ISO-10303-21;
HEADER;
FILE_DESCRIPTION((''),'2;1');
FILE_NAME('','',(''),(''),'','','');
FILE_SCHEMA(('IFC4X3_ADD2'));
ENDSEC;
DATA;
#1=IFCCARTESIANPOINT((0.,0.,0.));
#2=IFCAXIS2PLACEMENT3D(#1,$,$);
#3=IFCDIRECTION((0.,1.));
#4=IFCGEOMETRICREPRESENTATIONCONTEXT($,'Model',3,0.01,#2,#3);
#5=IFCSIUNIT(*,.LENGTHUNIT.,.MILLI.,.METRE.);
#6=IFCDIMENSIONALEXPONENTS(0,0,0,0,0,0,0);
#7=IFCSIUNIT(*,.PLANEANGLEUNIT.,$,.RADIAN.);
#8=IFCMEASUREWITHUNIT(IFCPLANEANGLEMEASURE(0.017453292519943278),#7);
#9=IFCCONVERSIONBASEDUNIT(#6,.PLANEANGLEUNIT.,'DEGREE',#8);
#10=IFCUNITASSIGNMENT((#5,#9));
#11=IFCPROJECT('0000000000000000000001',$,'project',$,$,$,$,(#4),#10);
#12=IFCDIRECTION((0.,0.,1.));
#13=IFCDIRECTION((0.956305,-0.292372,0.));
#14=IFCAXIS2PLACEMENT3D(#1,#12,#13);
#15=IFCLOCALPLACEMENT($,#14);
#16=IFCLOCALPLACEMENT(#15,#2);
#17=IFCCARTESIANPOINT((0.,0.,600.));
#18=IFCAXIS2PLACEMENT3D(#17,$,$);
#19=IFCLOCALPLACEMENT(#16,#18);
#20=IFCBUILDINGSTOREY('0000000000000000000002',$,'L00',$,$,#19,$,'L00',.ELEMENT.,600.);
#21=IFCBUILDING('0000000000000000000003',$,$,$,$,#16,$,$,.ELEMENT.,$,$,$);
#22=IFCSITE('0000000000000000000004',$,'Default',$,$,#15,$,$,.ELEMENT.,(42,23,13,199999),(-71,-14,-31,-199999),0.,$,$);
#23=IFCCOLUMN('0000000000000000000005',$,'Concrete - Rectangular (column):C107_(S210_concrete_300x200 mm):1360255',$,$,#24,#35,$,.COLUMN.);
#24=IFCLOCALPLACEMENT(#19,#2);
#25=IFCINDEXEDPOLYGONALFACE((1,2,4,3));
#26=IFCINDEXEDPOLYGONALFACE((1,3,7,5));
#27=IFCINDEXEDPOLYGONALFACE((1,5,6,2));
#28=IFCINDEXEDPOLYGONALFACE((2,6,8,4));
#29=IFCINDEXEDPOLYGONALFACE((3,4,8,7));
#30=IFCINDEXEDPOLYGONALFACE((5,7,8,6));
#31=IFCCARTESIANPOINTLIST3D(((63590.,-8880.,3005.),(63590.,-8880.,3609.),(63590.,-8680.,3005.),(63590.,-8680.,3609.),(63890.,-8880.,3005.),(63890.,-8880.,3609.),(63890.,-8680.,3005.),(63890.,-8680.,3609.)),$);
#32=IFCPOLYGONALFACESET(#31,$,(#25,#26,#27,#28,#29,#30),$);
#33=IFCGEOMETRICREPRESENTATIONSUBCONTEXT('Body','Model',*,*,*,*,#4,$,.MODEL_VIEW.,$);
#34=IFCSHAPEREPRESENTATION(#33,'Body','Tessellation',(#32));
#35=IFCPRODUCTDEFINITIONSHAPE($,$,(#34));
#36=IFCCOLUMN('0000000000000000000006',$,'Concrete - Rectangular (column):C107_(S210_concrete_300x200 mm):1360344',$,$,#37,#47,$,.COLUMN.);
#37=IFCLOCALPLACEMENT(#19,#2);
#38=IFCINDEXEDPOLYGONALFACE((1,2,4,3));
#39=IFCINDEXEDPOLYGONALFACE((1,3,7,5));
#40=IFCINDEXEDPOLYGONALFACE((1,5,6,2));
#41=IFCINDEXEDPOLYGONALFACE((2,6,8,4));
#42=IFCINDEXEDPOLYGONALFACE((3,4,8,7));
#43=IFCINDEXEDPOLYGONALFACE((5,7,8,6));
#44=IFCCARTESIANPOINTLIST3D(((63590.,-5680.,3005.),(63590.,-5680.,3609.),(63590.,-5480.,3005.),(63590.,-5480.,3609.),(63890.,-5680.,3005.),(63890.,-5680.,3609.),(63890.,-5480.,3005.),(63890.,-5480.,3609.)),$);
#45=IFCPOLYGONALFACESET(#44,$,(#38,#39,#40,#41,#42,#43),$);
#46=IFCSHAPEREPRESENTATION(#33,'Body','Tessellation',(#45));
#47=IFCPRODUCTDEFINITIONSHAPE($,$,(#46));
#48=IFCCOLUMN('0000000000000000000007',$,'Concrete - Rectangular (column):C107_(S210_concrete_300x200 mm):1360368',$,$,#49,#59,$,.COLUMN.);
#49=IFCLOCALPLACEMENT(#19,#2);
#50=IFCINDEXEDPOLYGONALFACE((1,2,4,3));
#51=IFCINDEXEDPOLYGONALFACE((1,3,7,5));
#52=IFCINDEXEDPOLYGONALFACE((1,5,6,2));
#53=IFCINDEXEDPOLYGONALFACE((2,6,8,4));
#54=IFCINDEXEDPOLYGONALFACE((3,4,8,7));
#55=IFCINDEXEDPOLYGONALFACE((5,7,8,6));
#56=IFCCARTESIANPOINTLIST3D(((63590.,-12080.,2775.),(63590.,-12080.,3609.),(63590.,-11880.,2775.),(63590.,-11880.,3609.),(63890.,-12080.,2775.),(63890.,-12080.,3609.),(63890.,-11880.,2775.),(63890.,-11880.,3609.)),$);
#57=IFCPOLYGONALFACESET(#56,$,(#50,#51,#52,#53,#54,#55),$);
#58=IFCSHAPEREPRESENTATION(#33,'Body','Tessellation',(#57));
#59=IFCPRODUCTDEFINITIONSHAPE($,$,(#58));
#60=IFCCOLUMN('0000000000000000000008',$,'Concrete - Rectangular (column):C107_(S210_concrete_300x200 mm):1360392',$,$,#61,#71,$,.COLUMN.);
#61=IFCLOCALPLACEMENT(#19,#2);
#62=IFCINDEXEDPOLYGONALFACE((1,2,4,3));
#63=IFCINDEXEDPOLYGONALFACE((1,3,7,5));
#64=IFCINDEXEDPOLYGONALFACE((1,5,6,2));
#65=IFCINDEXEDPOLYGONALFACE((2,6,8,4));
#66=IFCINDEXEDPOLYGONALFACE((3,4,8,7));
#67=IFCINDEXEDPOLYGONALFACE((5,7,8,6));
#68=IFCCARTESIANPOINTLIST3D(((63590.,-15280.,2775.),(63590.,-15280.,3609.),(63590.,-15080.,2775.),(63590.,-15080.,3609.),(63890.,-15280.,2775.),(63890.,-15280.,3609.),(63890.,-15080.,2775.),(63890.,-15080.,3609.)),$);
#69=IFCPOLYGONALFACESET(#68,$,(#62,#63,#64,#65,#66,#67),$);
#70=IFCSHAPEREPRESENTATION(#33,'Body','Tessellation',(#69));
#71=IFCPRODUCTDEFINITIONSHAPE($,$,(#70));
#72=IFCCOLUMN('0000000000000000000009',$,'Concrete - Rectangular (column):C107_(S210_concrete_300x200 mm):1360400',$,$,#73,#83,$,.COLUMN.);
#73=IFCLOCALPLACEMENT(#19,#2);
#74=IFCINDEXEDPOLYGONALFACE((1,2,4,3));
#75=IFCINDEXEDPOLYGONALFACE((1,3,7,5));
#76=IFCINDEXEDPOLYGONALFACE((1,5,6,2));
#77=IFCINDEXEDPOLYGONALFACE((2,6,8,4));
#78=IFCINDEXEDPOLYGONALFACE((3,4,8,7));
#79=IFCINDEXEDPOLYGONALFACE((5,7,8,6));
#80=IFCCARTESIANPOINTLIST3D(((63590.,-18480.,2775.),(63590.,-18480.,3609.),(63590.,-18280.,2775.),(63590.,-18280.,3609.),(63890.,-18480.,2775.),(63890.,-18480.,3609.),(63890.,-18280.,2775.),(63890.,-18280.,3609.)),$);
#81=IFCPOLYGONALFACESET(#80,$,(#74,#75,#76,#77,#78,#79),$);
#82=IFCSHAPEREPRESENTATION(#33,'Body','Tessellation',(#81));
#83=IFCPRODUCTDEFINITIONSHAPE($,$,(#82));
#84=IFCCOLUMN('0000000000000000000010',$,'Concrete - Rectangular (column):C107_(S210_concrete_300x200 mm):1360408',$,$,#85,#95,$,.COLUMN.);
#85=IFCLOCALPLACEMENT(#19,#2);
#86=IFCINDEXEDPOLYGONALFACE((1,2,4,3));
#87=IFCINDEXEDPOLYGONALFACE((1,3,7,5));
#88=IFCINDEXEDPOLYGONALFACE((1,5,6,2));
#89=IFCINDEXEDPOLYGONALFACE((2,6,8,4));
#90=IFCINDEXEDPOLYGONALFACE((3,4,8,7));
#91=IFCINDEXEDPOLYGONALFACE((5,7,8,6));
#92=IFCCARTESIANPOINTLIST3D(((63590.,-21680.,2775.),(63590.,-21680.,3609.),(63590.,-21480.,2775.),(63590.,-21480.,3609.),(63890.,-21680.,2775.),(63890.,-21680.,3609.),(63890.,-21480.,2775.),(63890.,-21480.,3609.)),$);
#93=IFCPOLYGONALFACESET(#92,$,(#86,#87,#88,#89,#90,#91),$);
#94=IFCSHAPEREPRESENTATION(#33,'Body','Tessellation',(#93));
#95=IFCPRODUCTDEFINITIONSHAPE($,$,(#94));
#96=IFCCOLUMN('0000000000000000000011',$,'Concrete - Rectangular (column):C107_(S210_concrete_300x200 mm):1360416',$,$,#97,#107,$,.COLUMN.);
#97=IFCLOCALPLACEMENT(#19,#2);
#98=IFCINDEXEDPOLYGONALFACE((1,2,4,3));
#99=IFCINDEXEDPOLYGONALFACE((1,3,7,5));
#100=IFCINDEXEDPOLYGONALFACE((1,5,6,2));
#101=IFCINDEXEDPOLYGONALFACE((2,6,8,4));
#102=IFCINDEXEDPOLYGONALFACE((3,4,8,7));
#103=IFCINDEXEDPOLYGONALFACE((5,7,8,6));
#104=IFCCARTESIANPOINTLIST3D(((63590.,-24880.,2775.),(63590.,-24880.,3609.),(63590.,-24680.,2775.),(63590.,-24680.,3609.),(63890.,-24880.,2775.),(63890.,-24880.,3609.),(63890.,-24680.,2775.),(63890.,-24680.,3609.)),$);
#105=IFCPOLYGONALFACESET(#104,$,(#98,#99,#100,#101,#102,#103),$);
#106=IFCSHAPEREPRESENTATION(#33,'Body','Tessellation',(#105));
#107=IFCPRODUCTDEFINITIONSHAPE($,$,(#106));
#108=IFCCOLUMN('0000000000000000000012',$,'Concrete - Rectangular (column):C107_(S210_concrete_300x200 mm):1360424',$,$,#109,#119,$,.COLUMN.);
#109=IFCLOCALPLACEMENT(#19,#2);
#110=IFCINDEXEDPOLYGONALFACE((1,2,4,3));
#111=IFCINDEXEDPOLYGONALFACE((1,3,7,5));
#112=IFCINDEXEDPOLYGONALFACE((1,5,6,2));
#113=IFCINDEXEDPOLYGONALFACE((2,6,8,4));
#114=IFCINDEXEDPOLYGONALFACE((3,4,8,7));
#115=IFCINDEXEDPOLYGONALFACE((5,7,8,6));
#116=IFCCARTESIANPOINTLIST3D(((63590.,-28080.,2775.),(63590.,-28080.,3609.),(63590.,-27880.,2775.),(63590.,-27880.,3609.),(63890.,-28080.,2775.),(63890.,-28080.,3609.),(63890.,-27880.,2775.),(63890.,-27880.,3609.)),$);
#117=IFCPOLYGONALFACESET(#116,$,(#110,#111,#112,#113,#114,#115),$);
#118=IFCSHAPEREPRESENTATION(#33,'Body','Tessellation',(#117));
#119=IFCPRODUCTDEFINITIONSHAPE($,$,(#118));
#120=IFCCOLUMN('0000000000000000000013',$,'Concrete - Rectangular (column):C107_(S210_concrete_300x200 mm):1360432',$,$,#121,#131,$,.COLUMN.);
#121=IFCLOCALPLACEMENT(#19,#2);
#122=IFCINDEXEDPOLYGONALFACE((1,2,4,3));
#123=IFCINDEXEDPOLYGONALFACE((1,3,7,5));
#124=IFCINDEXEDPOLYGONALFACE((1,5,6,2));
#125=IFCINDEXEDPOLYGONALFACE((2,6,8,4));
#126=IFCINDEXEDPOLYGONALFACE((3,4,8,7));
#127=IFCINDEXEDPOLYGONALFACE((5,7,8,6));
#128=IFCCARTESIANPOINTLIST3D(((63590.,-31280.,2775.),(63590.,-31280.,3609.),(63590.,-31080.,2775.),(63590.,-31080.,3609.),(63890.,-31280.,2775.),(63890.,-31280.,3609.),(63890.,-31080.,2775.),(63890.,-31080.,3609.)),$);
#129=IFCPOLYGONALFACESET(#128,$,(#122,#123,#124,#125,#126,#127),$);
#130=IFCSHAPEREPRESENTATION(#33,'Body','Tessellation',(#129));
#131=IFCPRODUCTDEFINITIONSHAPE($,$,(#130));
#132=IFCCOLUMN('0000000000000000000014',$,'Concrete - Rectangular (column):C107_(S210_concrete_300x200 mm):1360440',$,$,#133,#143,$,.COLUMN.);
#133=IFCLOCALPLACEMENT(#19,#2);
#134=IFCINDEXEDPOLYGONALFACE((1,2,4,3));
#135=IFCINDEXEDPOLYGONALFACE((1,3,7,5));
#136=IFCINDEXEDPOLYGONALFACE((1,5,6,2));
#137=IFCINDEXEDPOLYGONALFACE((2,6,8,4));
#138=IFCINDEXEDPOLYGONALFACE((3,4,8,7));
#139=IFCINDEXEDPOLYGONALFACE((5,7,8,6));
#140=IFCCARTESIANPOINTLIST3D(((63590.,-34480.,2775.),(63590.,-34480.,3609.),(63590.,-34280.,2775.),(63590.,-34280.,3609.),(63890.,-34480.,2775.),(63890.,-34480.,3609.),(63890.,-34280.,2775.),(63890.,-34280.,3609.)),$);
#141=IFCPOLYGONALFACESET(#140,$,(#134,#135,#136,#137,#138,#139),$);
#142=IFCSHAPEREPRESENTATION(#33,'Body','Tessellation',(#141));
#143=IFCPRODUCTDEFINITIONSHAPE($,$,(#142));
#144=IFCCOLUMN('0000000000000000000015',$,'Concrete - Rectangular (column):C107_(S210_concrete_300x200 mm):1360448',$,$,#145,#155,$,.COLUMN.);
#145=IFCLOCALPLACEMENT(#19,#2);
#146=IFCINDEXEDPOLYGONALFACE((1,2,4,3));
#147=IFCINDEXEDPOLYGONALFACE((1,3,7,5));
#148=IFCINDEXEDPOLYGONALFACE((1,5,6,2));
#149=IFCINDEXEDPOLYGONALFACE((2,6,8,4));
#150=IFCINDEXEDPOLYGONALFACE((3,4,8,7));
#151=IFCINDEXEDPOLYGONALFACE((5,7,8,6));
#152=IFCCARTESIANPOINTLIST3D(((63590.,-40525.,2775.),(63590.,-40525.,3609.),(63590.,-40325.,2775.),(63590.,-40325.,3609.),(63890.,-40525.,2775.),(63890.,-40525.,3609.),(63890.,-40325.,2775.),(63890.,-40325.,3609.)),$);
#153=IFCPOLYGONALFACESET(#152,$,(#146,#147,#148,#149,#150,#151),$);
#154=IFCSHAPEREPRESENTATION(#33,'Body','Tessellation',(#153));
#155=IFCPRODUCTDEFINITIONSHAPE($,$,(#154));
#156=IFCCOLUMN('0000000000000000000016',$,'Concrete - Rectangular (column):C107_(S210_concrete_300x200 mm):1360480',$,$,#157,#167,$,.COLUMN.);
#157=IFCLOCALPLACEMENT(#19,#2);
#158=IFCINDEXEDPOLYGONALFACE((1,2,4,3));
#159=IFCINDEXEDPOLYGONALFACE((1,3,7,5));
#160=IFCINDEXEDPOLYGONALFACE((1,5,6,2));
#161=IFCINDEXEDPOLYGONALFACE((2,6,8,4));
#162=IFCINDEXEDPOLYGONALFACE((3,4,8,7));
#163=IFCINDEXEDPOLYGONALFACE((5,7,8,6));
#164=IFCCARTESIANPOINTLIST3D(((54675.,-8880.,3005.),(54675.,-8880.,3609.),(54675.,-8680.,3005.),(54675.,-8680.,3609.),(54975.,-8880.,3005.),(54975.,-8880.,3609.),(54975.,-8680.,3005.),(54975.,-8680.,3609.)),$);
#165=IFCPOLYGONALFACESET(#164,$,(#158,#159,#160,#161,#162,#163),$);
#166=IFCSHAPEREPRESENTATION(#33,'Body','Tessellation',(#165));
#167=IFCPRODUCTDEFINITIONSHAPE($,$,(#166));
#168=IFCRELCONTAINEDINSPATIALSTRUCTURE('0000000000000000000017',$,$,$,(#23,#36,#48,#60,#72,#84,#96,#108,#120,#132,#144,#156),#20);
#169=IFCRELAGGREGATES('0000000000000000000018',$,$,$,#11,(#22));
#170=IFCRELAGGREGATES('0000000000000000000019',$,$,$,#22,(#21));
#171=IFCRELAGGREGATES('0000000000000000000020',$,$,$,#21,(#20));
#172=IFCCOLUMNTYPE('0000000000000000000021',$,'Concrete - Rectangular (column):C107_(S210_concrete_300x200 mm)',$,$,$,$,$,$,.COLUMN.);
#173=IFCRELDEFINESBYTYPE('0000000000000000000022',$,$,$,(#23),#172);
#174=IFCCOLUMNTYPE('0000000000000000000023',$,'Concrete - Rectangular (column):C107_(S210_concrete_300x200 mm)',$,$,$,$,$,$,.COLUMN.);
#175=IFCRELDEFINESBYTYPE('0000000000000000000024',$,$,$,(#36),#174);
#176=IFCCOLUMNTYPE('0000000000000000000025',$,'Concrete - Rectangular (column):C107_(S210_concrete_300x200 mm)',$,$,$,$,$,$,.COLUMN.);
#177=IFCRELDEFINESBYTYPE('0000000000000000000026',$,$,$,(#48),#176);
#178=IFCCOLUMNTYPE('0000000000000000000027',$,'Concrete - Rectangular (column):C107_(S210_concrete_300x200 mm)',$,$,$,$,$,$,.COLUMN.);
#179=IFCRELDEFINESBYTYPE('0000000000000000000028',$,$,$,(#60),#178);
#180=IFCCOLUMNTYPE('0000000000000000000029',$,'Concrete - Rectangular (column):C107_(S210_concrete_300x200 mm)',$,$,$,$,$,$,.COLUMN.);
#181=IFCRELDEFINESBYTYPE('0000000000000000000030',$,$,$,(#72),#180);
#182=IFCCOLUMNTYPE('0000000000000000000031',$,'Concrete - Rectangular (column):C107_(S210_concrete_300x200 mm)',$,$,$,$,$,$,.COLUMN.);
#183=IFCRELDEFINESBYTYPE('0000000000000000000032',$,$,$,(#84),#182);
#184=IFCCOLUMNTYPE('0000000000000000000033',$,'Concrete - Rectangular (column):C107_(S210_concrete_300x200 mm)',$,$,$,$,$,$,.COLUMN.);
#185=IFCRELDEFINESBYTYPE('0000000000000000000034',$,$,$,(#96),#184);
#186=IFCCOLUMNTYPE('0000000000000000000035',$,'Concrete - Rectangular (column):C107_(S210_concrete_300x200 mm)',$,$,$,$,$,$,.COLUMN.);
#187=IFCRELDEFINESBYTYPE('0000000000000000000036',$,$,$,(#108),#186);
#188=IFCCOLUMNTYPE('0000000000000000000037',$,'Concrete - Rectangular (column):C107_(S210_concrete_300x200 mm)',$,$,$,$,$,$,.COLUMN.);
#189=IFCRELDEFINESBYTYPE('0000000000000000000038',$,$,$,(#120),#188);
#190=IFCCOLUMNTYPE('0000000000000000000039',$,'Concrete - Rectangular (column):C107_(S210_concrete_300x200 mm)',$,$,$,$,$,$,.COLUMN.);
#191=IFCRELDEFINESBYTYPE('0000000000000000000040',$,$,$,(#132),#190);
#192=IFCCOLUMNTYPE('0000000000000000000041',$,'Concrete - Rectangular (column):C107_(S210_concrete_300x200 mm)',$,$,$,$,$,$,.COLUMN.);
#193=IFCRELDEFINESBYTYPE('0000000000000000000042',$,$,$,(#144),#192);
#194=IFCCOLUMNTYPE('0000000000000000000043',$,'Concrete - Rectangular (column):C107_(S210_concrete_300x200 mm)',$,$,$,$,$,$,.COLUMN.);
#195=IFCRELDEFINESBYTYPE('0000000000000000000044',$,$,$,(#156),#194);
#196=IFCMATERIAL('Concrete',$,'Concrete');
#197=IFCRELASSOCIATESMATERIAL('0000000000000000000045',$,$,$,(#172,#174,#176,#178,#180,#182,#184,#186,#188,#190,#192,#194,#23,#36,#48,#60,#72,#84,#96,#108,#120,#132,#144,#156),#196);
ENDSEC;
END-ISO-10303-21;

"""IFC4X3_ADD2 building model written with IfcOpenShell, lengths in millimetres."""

from ifc_helpers import new_model, entity, si_unit, converted_unit, direction, frame, frame_2d, origin, origin_2d_with_axis, place, context, subcontext, project, spatial, rectangle, extrude, source, transform, mapped, material, material_profile, profile_set, profile_usage, type_object, type_shapes, element, save


model = new_model("IFC4X3_ADD2")

# Units and contexts
model_context = context("Model", 3, precision=0.01, world=origin(), true_north=direction((0.0, 1.0)))
body_context = subcontext(model_context, "Body", "Model", "MODEL_VIEW")
ifc_project = project(units=[si_unit("LENGTHUNIT", "METRE", prefix="MILLI"), converted_unit("PLANEANGLEUNIT", "DEGREE", entity("IfcPlaneAngleMeasure", 0.017453292519943278), si_unit("PLANEANGLEUNIT", "RADIAN"), dimensions=[0, 0, 0, 0, 0, 0, 0])], contexts=[model_context])

# Site, building, storey
site_placement = place(None, frame((0.0, 0.0, 0.0), z_axis=(0.0, 0.0, 1.0), x_axis=(0.956305, -0.292372, 0.0)))
site = spatial("IfcSite", under=ifc_project, at=site_placement, Name="Default", CompositionType="ELEMENT", RefLatitude=(42, 23, 13, 199999), RefLongitude=(-71, -14, -31, -199999), RefElevation=0.0)
building_placement = place(site_placement, origin())
building = spatial("IfcBuilding", under=site, at=building_placement, CompositionType="ELEMENT")
storey_placement = place(building_placement, frame((0.0, 0.0, 600.0)))
storey = spatial("IfcBuildingStorey", under=building, at=storey_placement, Name="L00", LongName="L00", CompositionType="ELEMENT", Elevation=600.0)

# Columns
ifc_material = material(Name="Concrete", Category="Concrete")
ifc_material_profile = material_profile(ifc_material, rectangle(XDim=300.0, YDim=200.0, at=frame_2d((0.0, 0.0), x_axis=(1.0, 0.0))), Name="C107_(S210_concrete_300x200 mm)")
ifc_profile_set = profile_set([ifc_material_profile], Name="C107_(S210_concrete_300x200 mm)")
ifc_profile_usage = profile_usage(ifc_profile_set)
column_type_1 = type_object("IfcColumnType", Name="Concrete - Rectangular (column):C107_(S210_concrete_300x200 mm)", PredefinedType="COLUMN", material=ifc_profile_set)
shared_shape_1 = source(origin(), body_context, "Body", "SweptSolid", [
    extrude(rectangle(XDim=200.0, YDim=300.0, at=frame_2d((0.0, 0.0), x_axis=(1.0, 0.0))), frame((63740.0, -8780.0, 3605.0), z_axis=(0.0, 0.0, 1.0), x_axis=(0.0, 1.0, 0.0)), (0.0, 0.0, 1.0), 604.0),
])
type_shapes(column_type_1, [shared_shape_1])
column_1_placement = place(storey_placement, frame((0.0, 0.0, -600.0)))
element("IfcColumn", 1, at=column_1_placement, inside=storey, type_object=column_type_1, material=ifc_profile_usage, Name="Concrete - Rectangular (column):C107_(S210_concrete_300x200 mm):1360255", PredefinedType="COLUMN", context=body_context, shape_type="MappedRepresentation", body=[
    mapped(shared_shape_1, transform((0.0, 0.0, 0.0), scale=1.0)),
])
column_type_2 = type_object("IfcColumnType", Name="Concrete - Rectangular (column):C107_(S210_concrete_300x200 mm)", PredefinedType="COLUMN", material=ifc_profile_set)
shared_shape_2 = source(origin(), body_context, "Body", "SweptSolid", [
    extrude(rectangle(XDim=200.0, YDim=300.0, at=frame_2d((0.0, 0.0), x_axis=(1.0, 0.0))), frame((63740.0, -5580.0, 3605.0), z_axis=(0.0, 0.0, 1.0), x_axis=(0.0, 1.0, 0.0)), (0.0, 0.0, 1.0), 604.0),
])
type_shapes(column_type_2, [shared_shape_2])
column_2_placement = place(storey_placement, frame((0.0, 0.0, -600.0)))
element("IfcColumn", 2, at=column_2_placement, inside=storey, type_object=column_type_2, material=ifc_profile_usage, Name="Concrete - Rectangular (column):C107_(S210_concrete_300x200 mm):1360344", PredefinedType="COLUMN", context=body_context, shape_type="MappedRepresentation", body=[
    mapped(shared_shape_2, transform((0.0, 0.0, 0.0), scale=1.0)),
])
column_type_3 = type_object("IfcColumnType", Name="Concrete - Rectangular (column):C107_(S210_concrete_300x200 mm)", PredefinedType="COLUMN", material=ifc_profile_set)
shared_shape_3 = source(origin(), body_context, "Body", "SweptSolid", [
    extrude(rectangle(XDim=200.0, YDim=300.0, at=frame_2d((0.0, 0.0), x_axis=(1.0, 0.0))), frame((63740.0, -11980.0, 3375.0), z_axis=(0.0, 0.0, 1.0), x_axis=(0.0, 1.0, 0.0)), (0.0, 0.0, 1.0), 834.0),
])
type_shapes(column_type_3, [shared_shape_3])
column_3_placement = place(storey_placement, frame((0.0, 0.0, -600.0)))
element("IfcColumn", 3, at=column_3_placement, inside=storey, type_object=column_type_3, material=ifc_profile_usage, Name="Concrete - Rectangular (column):C107_(S210_concrete_300x200 mm):1360368", PredefinedType="COLUMN", context=body_context, shape_type="MappedRepresentation", body=[
    mapped(shared_shape_3, transform((0.0, 0.0, 0.0), scale=1.0)),
])
column_type_4 = type_object("IfcColumnType", Name="Concrete - Rectangular (column):C107_(S210_concrete_300x200 mm)", PredefinedType="COLUMN", material=ifc_profile_set)
shared_shape_4 = source(origin(), body_context, "Body", "SweptSolid", [
    extrude(rectangle(XDim=200.0, YDim=300.0, at=frame_2d((0.0, 0.0), x_axis=(1.0, 0.0))), frame((63740.0, -15180.0, 3375.0), z_axis=(0.0, 0.0, 1.0), x_axis=(0.0, 1.0, 0.0)), (0.0, 0.0, 1.0), 834.0),
])
type_shapes(column_type_4, [shared_shape_4])
column_4_placement = place(storey_placement, frame((0.0, 0.0, -600.0)))
element("IfcColumn", 4, at=column_4_placement, inside=storey, type_object=column_type_4, material=ifc_profile_usage, Name="Concrete - Rectangular (column):C107_(S210_concrete_300x200 mm):1360392", PredefinedType="COLUMN", context=body_context, shape_type="MappedRepresentation", body=[
    mapped(shared_shape_4, transform((0.0, 0.0, 0.0), scale=1.0)),
])
column_type_5 = type_object("IfcColumnType", Name="Concrete - Rectangular (column):C107_(S210_concrete_300x200 mm)", PredefinedType="COLUMN", material=ifc_profile_set)
shared_shape_5 = source(origin(), body_context, "Body", "SweptSolid", [
    extrude(rectangle(XDim=200.0, YDim=300.0, at=frame_2d((0.0, 0.0), x_axis=(1.0, 0.0))), frame((63740.0, -18380.0, 3375.0), z_axis=(0.0, 0.0, 1.0), x_axis=(0.0, 1.0, 0.0)), (0.0, 0.0, 1.0), 834.0),
])
type_shapes(column_type_5, [shared_shape_5])
column_5_placement = place(storey_placement, frame((0.0, 0.0, -600.0)))
element("IfcColumn", 5, at=column_5_placement, inside=storey, type_object=column_type_5, material=ifc_profile_usage, Name="Concrete - Rectangular (column):C107_(S210_concrete_300x200 mm):1360400", PredefinedType="COLUMN", context=body_context, shape_type="MappedRepresentation", body=[
    mapped(shared_shape_5, transform((0.0, 0.0, 0.0), scale=1.0)),
])
column_type_6 = type_object("IfcColumnType", Name="Concrete - Rectangular (column):C107_(S210_concrete_300x200 mm)", PredefinedType="COLUMN", material=ifc_profile_set)
shared_shape_6 = source(origin(), body_context, "Body", "SweptSolid", [
    extrude(rectangle(XDim=200.0, YDim=300.0, at=origin_2d_with_axis()), frame((63740.0, -21580.0, 3375.0), z_axis=(0.0, 0.0, 1.0), x_axis=(0.0, 1.0, 0.0)), (0.0, 0.0, 1.0), 834.0),
])
type_shapes(column_type_6, [shared_shape_6])
column_6_placement = place(storey_placement, frame((0.0, 0.0, -600.0)))
element("IfcColumn", 6, at=column_6_placement, inside=storey, type_object=column_type_6, material=ifc_profile_usage, Name="Concrete - Rectangular (column):C107_(S210_concrete_300x200 mm):1360408", PredefinedType="COLUMN", context=body_context, shape_type="MappedRepresentation", body=[
    mapped(shared_shape_6, transform((0.0, 0.0, 0.0), scale=1.0)),
])
column_type_7 = type_object("IfcColumnType", Name="Concrete - Rectangular (column):C107_(S210_concrete_300x200 mm)", PredefinedType="COLUMN", material=ifc_profile_set)
shared_shape_7 = source(origin(), body_context, "Body", "SweptSolid", [
    extrude(rectangle(XDim=200.0, YDim=300.0, at=origin_2d_with_axis()), frame((63740.0, -24780.0, 3375.0), z_axis=(0.0, 0.0, 1.0), x_axis=(0.0, 1.0, 0.0)), (0.0, 0.0, 1.0), 834.0),
])
type_shapes(column_type_7, [shared_shape_7])
column_7_placement = place(storey_placement, frame((0.0, 0.0, -600.0)))
element("IfcColumn", 7, at=column_7_placement, inside=storey, type_object=column_type_7, material=ifc_profile_usage, Name="Concrete - Rectangular (column):C107_(S210_concrete_300x200 mm):1360416", PredefinedType="COLUMN", context=body_context, shape_type="MappedRepresentation", body=[
    mapped(shared_shape_7, transform((0.0, 0.0, 0.0), scale=1.0)),
])
column_type_8 = type_object("IfcColumnType", Name="Concrete - Rectangular (column):C107_(S210_concrete_300x200 mm)", PredefinedType="COLUMN", material=ifc_profile_set)
shared_shape_8 = source(origin(), body_context, "Body", "SweptSolid", [
    extrude(rectangle(XDim=200.0, YDim=300.0, at=origin_2d_with_axis()), frame((63740.0, -27980.0, 3375.0), z_axis=(0.0, 0.0, 1.0), x_axis=(0.0, 1.0, 0.0)), (0.0, 0.0, 1.0), 834.0),
])
type_shapes(column_type_8, [shared_shape_8])
column_8_placement = place(storey_placement, frame((0.0, 0.0, -600.0)))
element("IfcColumn", 8, at=column_8_placement, inside=storey, type_object=column_type_8, material=ifc_profile_usage, Name="Concrete - Rectangular (column):C107_(S210_concrete_300x200 mm):1360424", PredefinedType="COLUMN", context=body_context, shape_type="MappedRepresentation", body=[
    mapped(shared_shape_8, transform((0.0, 0.0, 0.0), scale=1.0)),
])
column_type_9 = type_object("IfcColumnType", Name="Concrete - Rectangular (column):C107_(S210_concrete_300x200 mm)", PredefinedType="COLUMN", material=ifc_profile_set)
shared_shape_9 = source(origin(), body_context, "Body", "SweptSolid", [
    extrude(rectangle(XDim=200.0, YDim=300.0, at=origin_2d_with_axis()), frame((63740.0, -31180.0, 3375.0), z_axis=(0.0, 0.0, 1.0), x_axis=(0.0, 1.0, 0.0)), (0.0, 0.0, 1.0), 834.0),
])
type_shapes(column_type_9, [shared_shape_9])
column_9_placement = place(storey_placement, frame((0.0, 0.0, -600.0)))
element("IfcColumn", 9, at=column_9_placement, inside=storey, type_object=column_type_9, material=ifc_profile_usage, Name="Concrete - Rectangular (column):C107_(S210_concrete_300x200 mm):1360432", PredefinedType="COLUMN", context=body_context, shape_type="MappedRepresentation", body=[
    mapped(shared_shape_9, transform((0.0, 0.0, 0.0), scale=1.0)),
])
column_type_10 = type_object("IfcColumnType", Name="Concrete - Rectangular (column):C107_(S210_concrete_300x200 mm)", PredefinedType="COLUMN", material=ifc_profile_set)
shared_shape_10 = source(origin(), body_context, "Body", "SweptSolid", [
    extrude(rectangle(XDim=200.0, YDim=300.0, at=origin_2d_with_axis()), frame((63740.0, -34380.0, 3375.0), z_axis=(0.0, 0.0, 1.0), x_axis=(0.0, 1.0, 0.0)), (0.0, 0.0, 1.0), 834.0),
])
type_shapes(column_type_10, [shared_shape_10])
column_10_placement = place(storey_placement, frame((0.0, 0.0, -600.0)))
element("IfcColumn", 10, at=column_10_placement, inside=storey, type_object=column_type_10, material=ifc_profile_usage, Name="Concrete - Rectangular (column):C107_(S210_concrete_300x200 mm):1360440", PredefinedType="COLUMN", context=body_context, shape_type="MappedRepresentation", body=[
    mapped(shared_shape_10, transform((0.0, 0.0, 0.0), scale=1.0)),
])
column_type_11 = type_object("IfcColumnType", Name="Concrete - Rectangular (column):C107_(S210_concrete_300x200 mm)", PredefinedType="COLUMN", material=ifc_profile_set)
shared_shape_11 = source(origin(), body_context, "Body", "SweptSolid", [
    extrude(rectangle(XDim=200.0, YDim=300.0, at=frame_2d((0.0, 0.0), x_axis=(1.0, 0.0))), frame((63740.0, -40425.0, 3375.0), z_axis=(0.0, 0.0, 1.0), x_axis=(0.0, 1.0, 0.0)), (0.0, 0.0, 1.0), 834.0),
])
type_shapes(column_type_11, [shared_shape_11])
column_11_placement = place(storey_placement, frame((0.0, 0.0, -600.0)))
element("IfcColumn", 11, at=column_11_placement, inside=storey, type_object=column_type_11, material=ifc_profile_usage, Name="Concrete - Rectangular (column):C107_(S210_concrete_300x200 mm):1360448", PredefinedType="COLUMN", context=body_context, shape_type="MappedRepresentation", body=[
    mapped(shared_shape_11, transform((0.0, 0.0, 0.0), scale=1.0)),
])
column_type_12 = type_object("IfcColumnType", Name="Concrete - Rectangular (column):C107_(S210_concrete_300x200 mm)", PredefinedType="COLUMN", material=ifc_profile_set)
shared_shape_12 = source(origin(), body_context, "Body", "SweptSolid", [
    extrude(rectangle(XDim=200.0, YDim=300.0, at=frame_2d((0.0, 0.0), x_axis=(1.0, 0.0))), frame((54825.0, -8780.0, 3605.0), z_axis=(0.0, 0.0, 1.0), x_axis=(0.0, 1.0, 0.0)), (0.0, 0.0, 1.0), 604.0),
])
type_shapes(column_type_12, [shared_shape_12])
column_12_placement = place(storey_placement, frame((0.0, 0.0, -600.0)))
element("IfcColumn", 12, at=column_12_placement, inside=storey, type_object=column_type_12, material=ifc_profile_usage, Name="Concrete - Rectangular (column):C107_(S210_concrete_300x200 mm):1360480", PredefinedType="COLUMN", context=body_context, shape_type="MappedRepresentation", body=[
    mapped(shared_shape_12, transform((0.0, 0.0, 0.0), scale=1.0)),
])

save(model, "model.ifc")
